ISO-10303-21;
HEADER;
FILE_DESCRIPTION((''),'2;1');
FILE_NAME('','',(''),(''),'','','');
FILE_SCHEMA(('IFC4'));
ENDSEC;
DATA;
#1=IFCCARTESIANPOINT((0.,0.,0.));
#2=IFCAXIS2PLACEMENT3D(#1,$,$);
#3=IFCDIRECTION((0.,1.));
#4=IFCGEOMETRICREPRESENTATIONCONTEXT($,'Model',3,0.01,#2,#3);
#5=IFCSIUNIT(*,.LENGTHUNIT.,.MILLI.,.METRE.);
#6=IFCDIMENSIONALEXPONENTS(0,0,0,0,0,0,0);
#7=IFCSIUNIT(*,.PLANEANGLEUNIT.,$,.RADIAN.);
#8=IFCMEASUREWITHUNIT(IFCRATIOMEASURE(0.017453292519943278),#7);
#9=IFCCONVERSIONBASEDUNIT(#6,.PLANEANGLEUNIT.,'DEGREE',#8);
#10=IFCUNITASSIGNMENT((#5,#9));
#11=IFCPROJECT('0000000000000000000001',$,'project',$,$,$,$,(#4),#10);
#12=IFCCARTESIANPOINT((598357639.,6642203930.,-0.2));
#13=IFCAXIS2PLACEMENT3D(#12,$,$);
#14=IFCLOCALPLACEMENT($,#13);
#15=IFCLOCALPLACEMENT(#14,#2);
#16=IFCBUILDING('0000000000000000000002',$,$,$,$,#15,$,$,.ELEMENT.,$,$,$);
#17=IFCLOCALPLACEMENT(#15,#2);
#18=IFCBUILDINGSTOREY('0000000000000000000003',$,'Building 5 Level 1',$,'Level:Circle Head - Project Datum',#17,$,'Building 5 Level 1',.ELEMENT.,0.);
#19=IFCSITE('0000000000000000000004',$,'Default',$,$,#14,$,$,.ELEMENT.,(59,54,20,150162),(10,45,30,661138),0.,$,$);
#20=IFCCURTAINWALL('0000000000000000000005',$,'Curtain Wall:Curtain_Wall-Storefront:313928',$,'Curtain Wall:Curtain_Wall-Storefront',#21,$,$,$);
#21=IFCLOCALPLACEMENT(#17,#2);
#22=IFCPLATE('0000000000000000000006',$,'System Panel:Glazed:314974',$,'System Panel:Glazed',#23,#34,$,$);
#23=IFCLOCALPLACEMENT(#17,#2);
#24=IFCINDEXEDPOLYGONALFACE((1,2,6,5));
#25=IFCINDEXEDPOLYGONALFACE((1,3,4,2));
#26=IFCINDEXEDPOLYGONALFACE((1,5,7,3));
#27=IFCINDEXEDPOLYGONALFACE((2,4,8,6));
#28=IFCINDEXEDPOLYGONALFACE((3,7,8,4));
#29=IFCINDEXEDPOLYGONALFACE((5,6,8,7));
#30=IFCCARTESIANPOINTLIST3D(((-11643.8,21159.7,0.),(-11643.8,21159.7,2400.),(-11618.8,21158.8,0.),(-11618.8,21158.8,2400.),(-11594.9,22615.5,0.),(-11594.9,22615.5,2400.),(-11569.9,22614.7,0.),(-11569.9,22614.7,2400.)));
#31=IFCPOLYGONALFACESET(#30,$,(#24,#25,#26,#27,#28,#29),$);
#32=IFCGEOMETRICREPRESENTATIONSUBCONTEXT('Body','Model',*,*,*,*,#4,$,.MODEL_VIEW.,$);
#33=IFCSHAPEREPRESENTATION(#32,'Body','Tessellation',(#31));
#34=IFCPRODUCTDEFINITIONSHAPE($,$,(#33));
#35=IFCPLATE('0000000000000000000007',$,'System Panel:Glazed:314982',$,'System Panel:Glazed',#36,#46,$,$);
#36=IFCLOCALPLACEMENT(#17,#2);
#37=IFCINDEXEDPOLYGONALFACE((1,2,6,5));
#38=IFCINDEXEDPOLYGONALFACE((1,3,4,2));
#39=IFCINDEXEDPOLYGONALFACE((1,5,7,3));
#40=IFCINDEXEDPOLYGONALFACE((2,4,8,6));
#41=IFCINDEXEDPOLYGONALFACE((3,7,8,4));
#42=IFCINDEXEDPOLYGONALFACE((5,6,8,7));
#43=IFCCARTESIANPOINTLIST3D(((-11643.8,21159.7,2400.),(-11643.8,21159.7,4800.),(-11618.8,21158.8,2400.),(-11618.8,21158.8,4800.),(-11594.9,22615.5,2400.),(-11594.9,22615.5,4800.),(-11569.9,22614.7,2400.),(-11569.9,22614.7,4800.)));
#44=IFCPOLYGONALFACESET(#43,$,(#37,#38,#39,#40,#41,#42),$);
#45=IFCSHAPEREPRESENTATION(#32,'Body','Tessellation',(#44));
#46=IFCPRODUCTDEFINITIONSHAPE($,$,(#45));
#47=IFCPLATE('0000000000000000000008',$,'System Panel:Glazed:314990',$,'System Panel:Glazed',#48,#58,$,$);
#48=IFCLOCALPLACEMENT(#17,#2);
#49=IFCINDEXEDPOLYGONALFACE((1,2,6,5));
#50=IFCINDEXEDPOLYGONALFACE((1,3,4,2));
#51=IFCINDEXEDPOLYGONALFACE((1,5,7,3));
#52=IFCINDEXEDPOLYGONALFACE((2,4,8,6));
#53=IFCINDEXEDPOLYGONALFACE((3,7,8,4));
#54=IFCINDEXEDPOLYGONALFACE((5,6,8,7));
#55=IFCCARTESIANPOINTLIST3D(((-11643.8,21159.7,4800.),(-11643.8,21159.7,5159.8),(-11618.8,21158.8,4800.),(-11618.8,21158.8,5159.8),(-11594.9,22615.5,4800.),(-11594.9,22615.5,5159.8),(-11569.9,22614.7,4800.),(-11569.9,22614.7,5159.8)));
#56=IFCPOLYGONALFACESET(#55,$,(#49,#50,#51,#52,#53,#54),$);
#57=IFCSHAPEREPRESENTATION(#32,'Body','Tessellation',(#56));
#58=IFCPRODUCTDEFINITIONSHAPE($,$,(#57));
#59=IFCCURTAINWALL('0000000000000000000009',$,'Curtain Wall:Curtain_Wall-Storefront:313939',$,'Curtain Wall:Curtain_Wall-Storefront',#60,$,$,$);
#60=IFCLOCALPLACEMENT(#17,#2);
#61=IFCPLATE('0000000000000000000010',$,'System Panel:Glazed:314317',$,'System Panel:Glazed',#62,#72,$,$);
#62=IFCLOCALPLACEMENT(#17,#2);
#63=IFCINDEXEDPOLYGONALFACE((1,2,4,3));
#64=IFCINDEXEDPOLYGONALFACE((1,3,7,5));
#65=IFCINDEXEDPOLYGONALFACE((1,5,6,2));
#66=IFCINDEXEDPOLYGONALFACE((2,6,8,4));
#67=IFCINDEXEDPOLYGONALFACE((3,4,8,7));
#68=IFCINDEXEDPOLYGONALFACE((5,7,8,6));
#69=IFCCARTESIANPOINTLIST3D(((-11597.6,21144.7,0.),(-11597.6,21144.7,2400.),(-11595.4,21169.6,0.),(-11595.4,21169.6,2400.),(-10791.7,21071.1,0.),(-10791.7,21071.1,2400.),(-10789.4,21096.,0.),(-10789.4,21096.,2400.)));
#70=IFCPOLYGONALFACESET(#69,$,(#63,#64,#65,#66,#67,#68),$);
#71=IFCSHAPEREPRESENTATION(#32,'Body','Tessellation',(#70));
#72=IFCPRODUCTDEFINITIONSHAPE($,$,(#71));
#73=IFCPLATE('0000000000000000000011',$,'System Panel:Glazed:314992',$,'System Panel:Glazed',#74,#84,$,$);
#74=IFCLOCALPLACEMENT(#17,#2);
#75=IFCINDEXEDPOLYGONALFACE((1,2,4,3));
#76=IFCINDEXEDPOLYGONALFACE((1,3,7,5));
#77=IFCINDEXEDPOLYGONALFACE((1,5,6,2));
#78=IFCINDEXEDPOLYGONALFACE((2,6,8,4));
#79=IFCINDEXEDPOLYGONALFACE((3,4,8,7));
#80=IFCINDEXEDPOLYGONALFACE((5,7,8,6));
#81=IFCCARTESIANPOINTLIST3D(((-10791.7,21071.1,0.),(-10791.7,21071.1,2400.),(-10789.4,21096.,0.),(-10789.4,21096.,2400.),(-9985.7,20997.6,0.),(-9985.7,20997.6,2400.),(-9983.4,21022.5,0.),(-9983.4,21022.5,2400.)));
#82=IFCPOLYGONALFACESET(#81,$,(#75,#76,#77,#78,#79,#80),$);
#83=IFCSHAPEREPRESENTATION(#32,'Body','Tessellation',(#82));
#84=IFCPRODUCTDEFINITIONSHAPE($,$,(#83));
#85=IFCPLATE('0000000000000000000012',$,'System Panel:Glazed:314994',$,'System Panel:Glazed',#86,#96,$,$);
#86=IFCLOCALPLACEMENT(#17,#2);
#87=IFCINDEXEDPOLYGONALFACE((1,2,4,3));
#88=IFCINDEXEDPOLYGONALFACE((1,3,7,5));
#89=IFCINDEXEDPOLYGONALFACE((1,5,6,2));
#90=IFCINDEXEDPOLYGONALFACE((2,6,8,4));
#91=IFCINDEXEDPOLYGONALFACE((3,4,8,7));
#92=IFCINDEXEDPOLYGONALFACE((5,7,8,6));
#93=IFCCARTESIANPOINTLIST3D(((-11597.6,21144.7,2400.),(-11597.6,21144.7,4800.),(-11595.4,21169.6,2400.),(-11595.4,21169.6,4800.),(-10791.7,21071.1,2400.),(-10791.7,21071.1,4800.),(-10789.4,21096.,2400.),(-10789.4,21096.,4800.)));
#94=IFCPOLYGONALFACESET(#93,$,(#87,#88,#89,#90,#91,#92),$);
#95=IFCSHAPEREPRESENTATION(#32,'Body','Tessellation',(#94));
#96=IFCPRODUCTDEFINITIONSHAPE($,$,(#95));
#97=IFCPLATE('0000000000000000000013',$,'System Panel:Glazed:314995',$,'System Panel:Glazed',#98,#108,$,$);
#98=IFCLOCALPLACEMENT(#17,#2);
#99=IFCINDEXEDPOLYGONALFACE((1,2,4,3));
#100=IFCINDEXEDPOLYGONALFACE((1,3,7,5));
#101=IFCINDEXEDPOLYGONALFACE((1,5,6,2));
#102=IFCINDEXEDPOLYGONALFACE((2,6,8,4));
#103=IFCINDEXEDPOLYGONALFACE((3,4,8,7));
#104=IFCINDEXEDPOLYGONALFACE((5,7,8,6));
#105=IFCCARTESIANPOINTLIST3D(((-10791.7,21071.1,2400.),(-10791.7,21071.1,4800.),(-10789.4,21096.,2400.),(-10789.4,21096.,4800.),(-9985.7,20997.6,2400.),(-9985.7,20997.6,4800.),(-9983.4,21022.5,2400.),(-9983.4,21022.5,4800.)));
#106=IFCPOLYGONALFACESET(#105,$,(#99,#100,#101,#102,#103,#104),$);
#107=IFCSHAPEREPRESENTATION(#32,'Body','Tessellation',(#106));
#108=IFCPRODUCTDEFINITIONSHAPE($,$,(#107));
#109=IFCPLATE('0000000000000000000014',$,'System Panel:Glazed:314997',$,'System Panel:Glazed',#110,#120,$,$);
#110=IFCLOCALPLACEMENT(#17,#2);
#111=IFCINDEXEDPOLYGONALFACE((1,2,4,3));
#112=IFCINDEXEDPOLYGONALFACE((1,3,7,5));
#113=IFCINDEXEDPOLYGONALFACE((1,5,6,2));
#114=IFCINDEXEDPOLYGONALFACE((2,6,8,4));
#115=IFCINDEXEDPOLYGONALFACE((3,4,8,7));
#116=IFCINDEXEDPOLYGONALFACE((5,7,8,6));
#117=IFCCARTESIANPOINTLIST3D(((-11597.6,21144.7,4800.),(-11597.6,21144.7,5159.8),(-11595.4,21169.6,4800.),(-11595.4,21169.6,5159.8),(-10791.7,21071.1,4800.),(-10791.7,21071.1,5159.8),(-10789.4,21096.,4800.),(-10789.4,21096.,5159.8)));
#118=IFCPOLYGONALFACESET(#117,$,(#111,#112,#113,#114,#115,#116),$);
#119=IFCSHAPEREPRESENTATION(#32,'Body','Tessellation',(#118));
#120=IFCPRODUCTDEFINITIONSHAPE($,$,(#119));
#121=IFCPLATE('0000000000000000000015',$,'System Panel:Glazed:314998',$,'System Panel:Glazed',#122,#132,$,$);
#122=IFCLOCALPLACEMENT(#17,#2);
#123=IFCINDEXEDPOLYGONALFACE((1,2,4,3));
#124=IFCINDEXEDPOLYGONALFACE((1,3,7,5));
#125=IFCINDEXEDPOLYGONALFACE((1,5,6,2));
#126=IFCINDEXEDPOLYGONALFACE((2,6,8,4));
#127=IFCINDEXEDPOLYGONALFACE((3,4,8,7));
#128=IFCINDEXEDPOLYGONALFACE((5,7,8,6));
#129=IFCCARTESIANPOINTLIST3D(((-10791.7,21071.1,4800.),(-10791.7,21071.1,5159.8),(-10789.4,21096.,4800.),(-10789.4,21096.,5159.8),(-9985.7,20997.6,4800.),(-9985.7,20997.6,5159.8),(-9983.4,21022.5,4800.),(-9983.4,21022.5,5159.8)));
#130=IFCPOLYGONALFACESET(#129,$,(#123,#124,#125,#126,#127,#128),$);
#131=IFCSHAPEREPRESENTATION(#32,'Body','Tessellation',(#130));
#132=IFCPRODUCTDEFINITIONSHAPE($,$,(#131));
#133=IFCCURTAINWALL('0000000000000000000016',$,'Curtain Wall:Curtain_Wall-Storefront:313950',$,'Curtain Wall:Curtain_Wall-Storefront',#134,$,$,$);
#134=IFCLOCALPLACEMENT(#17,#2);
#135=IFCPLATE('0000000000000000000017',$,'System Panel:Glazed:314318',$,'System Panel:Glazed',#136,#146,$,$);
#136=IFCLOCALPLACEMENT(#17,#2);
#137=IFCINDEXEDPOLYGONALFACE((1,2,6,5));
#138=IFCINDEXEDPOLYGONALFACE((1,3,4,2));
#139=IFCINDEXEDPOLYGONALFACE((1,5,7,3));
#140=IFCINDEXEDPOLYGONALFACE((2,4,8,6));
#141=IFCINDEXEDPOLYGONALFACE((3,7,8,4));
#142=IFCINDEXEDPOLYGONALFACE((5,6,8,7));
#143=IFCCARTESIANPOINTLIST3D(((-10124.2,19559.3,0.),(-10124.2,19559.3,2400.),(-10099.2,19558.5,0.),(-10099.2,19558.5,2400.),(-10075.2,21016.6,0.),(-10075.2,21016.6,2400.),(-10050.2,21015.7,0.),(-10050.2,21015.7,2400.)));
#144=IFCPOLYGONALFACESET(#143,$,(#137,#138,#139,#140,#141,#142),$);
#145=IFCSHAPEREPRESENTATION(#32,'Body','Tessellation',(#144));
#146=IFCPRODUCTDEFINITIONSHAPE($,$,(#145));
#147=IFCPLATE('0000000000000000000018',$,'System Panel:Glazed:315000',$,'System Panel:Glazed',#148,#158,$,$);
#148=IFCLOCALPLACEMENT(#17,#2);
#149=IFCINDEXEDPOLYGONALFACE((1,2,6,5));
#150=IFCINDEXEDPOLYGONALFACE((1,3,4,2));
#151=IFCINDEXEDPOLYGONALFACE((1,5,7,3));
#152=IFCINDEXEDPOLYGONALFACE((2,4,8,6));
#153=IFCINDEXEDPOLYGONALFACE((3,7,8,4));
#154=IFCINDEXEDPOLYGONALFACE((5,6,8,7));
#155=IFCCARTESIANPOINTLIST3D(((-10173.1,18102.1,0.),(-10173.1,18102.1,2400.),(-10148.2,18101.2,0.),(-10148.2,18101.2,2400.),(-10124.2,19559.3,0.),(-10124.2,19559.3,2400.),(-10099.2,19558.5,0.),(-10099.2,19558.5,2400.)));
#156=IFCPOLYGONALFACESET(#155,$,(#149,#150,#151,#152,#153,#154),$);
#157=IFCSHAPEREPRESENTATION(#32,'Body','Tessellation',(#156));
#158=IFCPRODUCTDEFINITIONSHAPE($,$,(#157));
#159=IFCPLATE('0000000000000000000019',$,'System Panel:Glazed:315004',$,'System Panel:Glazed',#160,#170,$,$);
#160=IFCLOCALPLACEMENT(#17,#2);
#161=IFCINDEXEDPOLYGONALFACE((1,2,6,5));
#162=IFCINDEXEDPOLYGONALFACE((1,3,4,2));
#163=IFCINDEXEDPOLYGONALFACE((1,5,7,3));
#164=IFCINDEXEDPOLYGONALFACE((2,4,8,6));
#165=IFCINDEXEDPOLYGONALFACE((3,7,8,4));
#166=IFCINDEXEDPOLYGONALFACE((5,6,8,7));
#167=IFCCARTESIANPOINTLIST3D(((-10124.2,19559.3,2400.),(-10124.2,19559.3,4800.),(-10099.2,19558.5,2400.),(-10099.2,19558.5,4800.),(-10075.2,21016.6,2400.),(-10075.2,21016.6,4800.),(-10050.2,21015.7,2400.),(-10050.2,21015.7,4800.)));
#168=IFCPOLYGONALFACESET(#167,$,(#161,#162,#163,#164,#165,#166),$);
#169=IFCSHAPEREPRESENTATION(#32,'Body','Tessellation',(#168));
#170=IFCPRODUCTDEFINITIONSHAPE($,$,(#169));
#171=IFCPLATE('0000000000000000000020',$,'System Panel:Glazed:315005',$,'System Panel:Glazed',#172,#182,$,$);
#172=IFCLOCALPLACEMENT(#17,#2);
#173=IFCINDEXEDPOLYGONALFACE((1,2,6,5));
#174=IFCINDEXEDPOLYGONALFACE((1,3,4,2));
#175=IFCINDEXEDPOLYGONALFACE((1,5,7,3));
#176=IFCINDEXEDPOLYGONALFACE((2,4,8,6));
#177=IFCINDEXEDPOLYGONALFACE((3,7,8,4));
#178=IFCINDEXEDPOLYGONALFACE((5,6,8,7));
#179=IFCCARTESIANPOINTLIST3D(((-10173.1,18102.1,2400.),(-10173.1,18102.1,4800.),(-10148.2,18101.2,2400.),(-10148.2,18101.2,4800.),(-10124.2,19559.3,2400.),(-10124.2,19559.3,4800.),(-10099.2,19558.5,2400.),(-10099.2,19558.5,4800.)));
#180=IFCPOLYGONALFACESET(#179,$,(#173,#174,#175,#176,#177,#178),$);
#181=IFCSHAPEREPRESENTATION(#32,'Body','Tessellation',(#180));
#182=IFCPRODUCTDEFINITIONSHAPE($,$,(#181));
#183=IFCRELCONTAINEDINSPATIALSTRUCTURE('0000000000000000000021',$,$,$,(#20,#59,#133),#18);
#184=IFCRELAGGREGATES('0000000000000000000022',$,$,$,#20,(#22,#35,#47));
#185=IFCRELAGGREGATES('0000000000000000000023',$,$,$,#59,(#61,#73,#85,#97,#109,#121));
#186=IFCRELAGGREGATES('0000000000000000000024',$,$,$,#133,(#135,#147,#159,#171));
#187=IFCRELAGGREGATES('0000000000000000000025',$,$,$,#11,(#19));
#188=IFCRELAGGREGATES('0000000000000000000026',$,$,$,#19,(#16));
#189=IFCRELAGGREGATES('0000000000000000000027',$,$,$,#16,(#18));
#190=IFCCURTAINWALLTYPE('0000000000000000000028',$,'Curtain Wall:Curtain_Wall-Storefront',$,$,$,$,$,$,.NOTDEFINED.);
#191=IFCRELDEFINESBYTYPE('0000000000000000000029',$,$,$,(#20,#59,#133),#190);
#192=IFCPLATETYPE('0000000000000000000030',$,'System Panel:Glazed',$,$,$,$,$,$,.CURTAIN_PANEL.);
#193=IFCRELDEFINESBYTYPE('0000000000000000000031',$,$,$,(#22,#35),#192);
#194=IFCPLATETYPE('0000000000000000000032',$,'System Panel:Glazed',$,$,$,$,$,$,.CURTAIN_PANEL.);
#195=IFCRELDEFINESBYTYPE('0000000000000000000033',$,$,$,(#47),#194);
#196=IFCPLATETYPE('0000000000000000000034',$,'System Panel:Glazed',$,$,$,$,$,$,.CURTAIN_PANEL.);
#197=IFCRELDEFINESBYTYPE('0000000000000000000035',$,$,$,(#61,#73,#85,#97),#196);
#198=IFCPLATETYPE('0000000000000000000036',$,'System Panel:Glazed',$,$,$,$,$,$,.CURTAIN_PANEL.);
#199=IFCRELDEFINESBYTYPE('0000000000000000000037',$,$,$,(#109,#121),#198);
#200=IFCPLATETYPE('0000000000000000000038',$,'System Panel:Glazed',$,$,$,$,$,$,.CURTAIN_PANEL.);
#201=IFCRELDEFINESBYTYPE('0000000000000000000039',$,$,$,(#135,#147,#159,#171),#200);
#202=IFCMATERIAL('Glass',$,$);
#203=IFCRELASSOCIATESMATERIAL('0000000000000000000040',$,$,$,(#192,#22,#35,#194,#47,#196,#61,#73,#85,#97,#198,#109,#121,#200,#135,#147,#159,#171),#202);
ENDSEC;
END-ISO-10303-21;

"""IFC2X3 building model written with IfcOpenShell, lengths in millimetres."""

from ifc_helpers import new_model, entity, si_unit, converted_unit, direction, frame, frame_2d, origin, place, context, subcontext, project, spatial, rectangle, extrude, source, transform, mapped, material, type_object, type_shapes, element, aggregate, save


model = new_model("IFC2X3")

# Units and contexts
model_context = context("Model", 3, precision=0.01, world=origin(), true_north=direction((0.0, 1.0)))
body_context = subcontext(model_context, "Body", "Model", "MODEL_VIEW")
ifc_project = project(units=[si_unit("LENGTHUNIT", "METRE", prefix="MILLI"), converted_unit("PLANEANGLEUNIT", "DEGREE", entity("IfcRatioMeasure", 0.017453292519943278), si_unit("PLANEANGLEUNIT", "RADIAN"), dimensions=[0, 0, 0, 0, 0, 0, 0])], contexts=[model_context])

# Site, building, storey
site_placement = place(None, frame((598357639.0, 6642203930.0, -0.2)))
site = spatial("IfcSite", under=ifc_project, at=site_placement, Name="Default", CompositionType="ELEMENT", RefLatitude=(59, 54, 20, 150162), RefLongitude=(10, 45, 30, 661138), RefElevation=0.0)
building_placement = place(site_placement, origin())
building = spatial("IfcBuilding", under=site, at=building_placement, CompositionType="ELEMENT")
storey_placement = place(building_placement, origin())
storey = spatial("IfcBuildingStorey", under=building, at=storey_placement, Name="Building 5 Level 1", ObjectType="Level:Circle Head - Project Datum", LongName="Building 5 Level 1", CompositionType="ELEMENT", Elevation=0.0)

# Curtain walls, plates
curtain_wall_type = type_object("IfcCurtainWallType", Name="Curtain Wall:Curtain_Wall-Storefront", PredefinedType="NOTDEFINED")
curtain_wall_1_placement = place(storey_placement, origin())
curtain_wall_1 = element("IfcCurtainWall", 1, at=curtain_wall_1_placement, inside=storey, type_object=curtain_wall_type, Name="Curtain Wall:Curtain_Wall-Storefront:313928", ObjectType="Curtain Wall:Curtain_Wall-Storefront")
ifc_material = material(Name="Glass")
plate_type_1 = type_object("IfcPlateType", Name="System Panel:Glazed", PredefinedType="CURTAIN_PANEL", material=ifc_material)
shared_shape_1 = source(origin(), body_context, "Body", "SweptSolid", [
    extrude(rectangle(XDim=25.0, YDim=1456.7, at=frame_2d((0.0, 0.0), x_axis=(1.0, 0.0))), frame((0.0, -37.0, 0.0), z_axis=(0.0, 0.0, 1.0), x_axis=(0.0, 1.0, 0.0)), (0.0, 0.0, 1.0), 2400.0),
])
type_shapes(plate_type_1, [shared_shape_1])
plate_1_placement = place(curtain_wall_1_placement, frame((-11569.9, 21886.0, 0.0), z_axis=(0.0, 0.0, 1.0), x_axis=(-0.033601, -0.999435, 0.0)))
plate_1 = element("IfcPlate", 2, at=plate_1_placement, type_object=plate_type_1, material=ifc_material, Name="System Panel:Glazed:314974", ObjectType="System Panel:Glazed", context=body_context, shape_type="MappedRepresentation", body=[
    mapped(shared_shape_1, transform((0.0, 0.0, 0.0), scale=1.0)),
])
plate_2_placement = place(curtain_wall_1_placement, frame((-11569.9, 21886.0, 2400.0), z_axis=(0.0, 0.0, 1.0), x_axis=(-0.033601, -0.999435, 0.0)))
plate_2 = element("IfcPlate", 3, at=plate_2_placement, type_object=plate_type_1, material=ifc_material, Name="System Panel:Glazed:314982", ObjectType="System Panel:Glazed", context=body_context, shape_type="MappedRepresentation", body=[
    mapped(shared_shape_1, transform((0.0, 0.0, 0.0), scale=1.0)),
])
plate_type_2 = type_object("IfcPlateType", Name="System Panel:Glazed", PredefinedType="CURTAIN_PANEL", material=ifc_material)
shared_shape_2 = source(origin(), body_context, "Body", "SweptSolid", [
    extrude(rectangle(XDim=25.0, YDim=1456.7, at=frame_2d((0.0, 0.0), x_axis=(1.0, 0.0))), frame((0.0, -37.0, 0.0), z_axis=(0.0, 0.0, 1.0), x_axis=(0.0, 1.0, 0.0)), (0.0, 0.0, 1.0), 359.8),
])
type_shapes(plate_type_2, [shared_shape_2])
plate_3_placement = place(curtain_wall_1_placement, frame((-11569.9, 21886.0, 4800.0), z_axis=(0.0, 0.0, 1.0), x_axis=(-0.033601, -0.999435, 0.0)))
plate_3 = element("IfcPlate", 4, at=plate_3_placement, type_object=plate_type_2, material=ifc_material, Name="System Panel:Glazed:314990", ObjectType="System Panel:Glazed", context=body_context, shape_type="MappedRepresentation", body=[
    mapped(shared_shape_2, transform((0.0, 0.0, 0.0), scale=1.0)),
])
aggregate(curtain_wall_1, [plate_1, plate_2, plate_3])
curtain_wall_2_placement = place(storey_placement, origin())
curtain_wall_2 = element("IfcCurtainWall", 5, at=curtain_wall_2_placement, inside=storey, type_object=curtain_wall_type, Name="Curtain Wall:Curtain_Wall-Storefront:313939", ObjectType="Curtain Wall:Curtain_Wall-Storefront")
plate_type_3 = type_object("IfcPlateType", Name="System Panel:Glazed", PredefinedType="CURTAIN_PANEL", material=ifc_material)
shared_shape_3 = source(origin(), body_context, "Body", "SweptSolid", [
    extrude(rectangle(XDim=25.0, YDim=809.3, at=frame_2d((0.0, 0.0), x_axis=(1.0, 0.0))), frame((0.0, -37.0, 0.0), z_axis=(0.0, 0.0, 1.0), x_axis=(0.0, 1.0, 0.0)), (0.0, 0.0, 1.0), 2400.0),
])
type_shapes(plate_type_3, [shared_shape_3])
plate_4_placement = place(curtain_wall_2_placement, frame((-11190.1, 21157.2, 0.0), z_axis=(0.0, 0.0, 1.0), x_axis=(0.995865, -0.090846, 0.0)))
plate_4 = element("IfcPlate", 6, at=plate_4_placement, type_object=plate_type_3, material=ifc_material, Name="System Panel:Glazed:314317", ObjectType="System Panel:Glazed", context=body_context, shape_type="MappedRepresentation", body=[
    mapped(shared_shape_3, transform((0.0, 0.0, 0.0), scale=1.0)),
])
plate_5_placement = place(curtain_wall_2_placement, frame((-10384.2, 21083.7, 0.0), z_axis=(0.0, 0.0, 1.0), x_axis=(0.995865, -0.090846, 0.0)))
plate_5 = element("IfcPlate", 7, at=plate_5_placement, type_object=plate_type_3, material=ifc_material, Name="System Panel:Glazed:314992", ObjectType="System Panel:Glazed", context=body_context, shape_type="MappedRepresentation", body=[
    mapped(shared_shape_3, transform((0.0, 0.0, 0.0), scale=1.0)),
])
plate_6_placement = place(curtain_wall_2_placement, frame((-11190.1, 21157.2, 2400.0), z_axis=(0.0, 0.0, 1.0), x_axis=(0.995865, -0.090846, 0.0)))
plate_6 = element("IfcPlate", 8, at=plate_6_placement, type_object=plate_type_3, material=ifc_material, Name="System Panel:Glazed:314994", ObjectType="System Panel:Glazed", context=body_context, shape_type="MappedRepresentation", body=[
    mapped(shared_shape_3, transform((0.0, 0.0, 0.0), scale=1.0)),
])
plate_7_placement = place(curtain_wall_2_placement, frame((-10384.2, 21083.7, 2400.0), z_axis=(0.0, 0.0, 1.0), x_axis=(0.995865, -0.090846, 0.0)))
plate_7 = element("IfcPlate", 9, at=plate_7_placement, type_object=plate_type_3, material=ifc_material, Name="System Panel:Glazed:314995", ObjectType="System Panel:Glazed", context=body_context, shape_type="MappedRepresentation", body=[
    mapped(shared_shape_3, transform((0.0, 0.0, 0.0), scale=1.0)),
])
plate_type_4 = type_object("IfcPlateType", Name="System Panel:Glazed", PredefinedType="CURTAIN_PANEL", material=ifc_material)
shared_shape_4 = source(origin(), body_context, "Body", "SweptSolid", [
    extrude(rectangle(XDim=25.0, YDim=809.3, at=frame_2d((0.0, 0.0), x_axis=(1.0, 0.0))), frame((0.0, -37.0, 0.0), z_axis=(0.0, 0.0, 1.0), x_axis=(0.0, 1.0, 0.0)), (0.0, 0.0, 1.0), 359.8),
])
type_shapes(plate_type_4, [shared_shape_4])
plate_8_placement = place(curtain_wall_2_placement, frame((-11190.1, 21157.2, 4800.0), z_axis=(0.0, 0.0, 1.0), x_axis=(0.995865, -0.090846, 0.0)))
plate_8 = element("IfcPlate", 10, at=plate_8_placement, type_object=plate_type_4, material=ifc_material, Name="System Panel:Glazed:314997", ObjectType="System Panel:Glazed", context=body_context, shape_type="MappedRepresentation", body=[
    mapped(shared_shape_4, transform((0.0, 0.0, 0.0), scale=1.0)),
])
plate_9_placement = place(curtain_wall_2_placement, frame((-10384.2, 21083.7, 4800.0), z_axis=(0.0, 0.0, 1.0), x_axis=(0.995865, -0.090846, 0.0)))
plate_9 = element("IfcPlate", 11, at=plate_9_placement, type_object=plate_type_4, material=ifc_material, Name="System Panel:Glazed:314998", ObjectType="System Panel:Glazed", context=body_context, shape_type="MappedRepresentation", body=[
    mapped(shared_shape_4, transform((0.0, 0.0, 0.0), scale=1.0)),
])
aggregate(curtain_wall_2, [plate_4, plate_5, plate_6, plate_7, plate_8, plate_9])
curtain_wall_3_placement = place(storey_placement, origin())
curtain_wall_3 = element("IfcCurtainWall", 12, at=curtain_wall_3_placement, inside=storey, type_object=curtain_wall_type, Name="Curtain Wall:Curtain_Wall-Storefront:313950", ObjectType="Curtain Wall:Curtain_Wall-Storefront")
plate_type_5 = type_object("IfcPlateType", Name="System Panel:Glazed", PredefinedType="CURTAIN_PANEL", material=ifc_material)
shared_shape_5 = source(origin(), body_context, "Body", "SweptSolid", [
    extrude(rectangle(XDim=25.0, YDim=1458.1, at=frame_2d((0.0, 0.0), x_axis=(1.0, 0.0))), frame((0.0, -37.0, 0.0), z_axis=(0.0, 0.0, 1.0), x_axis=(0.0, 1.0, 0.0)), (0.0, 0.0, 1.0), 2400.0),
])
type_shapes(plate_type_5, [shared_shape_5])
plate_10_placement = place(curtain_wall_3_placement, frame((-10050.2, 20286.3, 0.0), z_axis=(0.0, 0.0, 1.0), x_axis=(-0.033601, -0.999435, 0.0)))
plate_10 = element("IfcPlate", 13, at=plate_10_placement, type_object=plate_type_5, material=ifc_material, Name="System Panel:Glazed:314318", ObjectType="System Panel:Glazed", context=body_context, shape_type="MappedRepresentation", body=[
    mapped(shared_shape_5, transform((0.0, 0.0, 0.0), scale=1.0)),
])
plate_11_placement = place(curtain_wall_3_placement, frame((-10099.2, 18829.0, 0.0), z_axis=(0.0, 0.0, 1.0), x_axis=(-0.033601, -0.999435, 0.0)))
plate_11 = element("IfcPlate", 14, at=plate_11_placement, type_object=plate_type_5, material=ifc_material, Name="System Panel:Glazed:315000", ObjectType="System Panel:Glazed", context=body_context, shape_type="MappedRepresentation", body=[
    mapped(shared_shape_5, transform((0.0, 0.0, 0.0), scale=1.0)),
])
plate_12_placement = place(curtain_wall_3_placement, frame((-10050.2, 20286.3, 2400.0), z_axis=(0.0, 0.0, 1.0), x_axis=(-0.033601, -0.999435, 0.0)))
plate_12 = element("IfcPlate", 15, at=plate_12_placement, type_object=plate_type_5, material=ifc_material, Name="System Panel:Glazed:315004", ObjectType="System Panel:Glazed", context=body_context, shape_type="MappedRepresentation", body=[
    mapped(shared_shape_5, transform((0.0, 0.0, 0.0), scale=1.0)),
])
plate_13_placement = place(curtain_wall_3_placement, frame((-10099.2, 18829.0, 2400.0), z_axis=(0.0, 0.0, 1.0), x_axis=(-0.033601, -0.999435, 0.0)))
plate_13 = element("IfcPlate", 16, at=plate_13_placement, type_object=plate_type_5, material=ifc_material, Name="System Panel:Glazed:315005", ObjectType="System Panel:Glazed", context=body_context, shape_type="MappedRepresentation", body=[
    mapped(shared_shape_5, transform((0.0, 0.0, 0.0), scale=1.0)),
])
aggregate(curtain_wall_3, [plate_10, plate_11, plate_12, plate_13])

save(model, "model.ifc")
